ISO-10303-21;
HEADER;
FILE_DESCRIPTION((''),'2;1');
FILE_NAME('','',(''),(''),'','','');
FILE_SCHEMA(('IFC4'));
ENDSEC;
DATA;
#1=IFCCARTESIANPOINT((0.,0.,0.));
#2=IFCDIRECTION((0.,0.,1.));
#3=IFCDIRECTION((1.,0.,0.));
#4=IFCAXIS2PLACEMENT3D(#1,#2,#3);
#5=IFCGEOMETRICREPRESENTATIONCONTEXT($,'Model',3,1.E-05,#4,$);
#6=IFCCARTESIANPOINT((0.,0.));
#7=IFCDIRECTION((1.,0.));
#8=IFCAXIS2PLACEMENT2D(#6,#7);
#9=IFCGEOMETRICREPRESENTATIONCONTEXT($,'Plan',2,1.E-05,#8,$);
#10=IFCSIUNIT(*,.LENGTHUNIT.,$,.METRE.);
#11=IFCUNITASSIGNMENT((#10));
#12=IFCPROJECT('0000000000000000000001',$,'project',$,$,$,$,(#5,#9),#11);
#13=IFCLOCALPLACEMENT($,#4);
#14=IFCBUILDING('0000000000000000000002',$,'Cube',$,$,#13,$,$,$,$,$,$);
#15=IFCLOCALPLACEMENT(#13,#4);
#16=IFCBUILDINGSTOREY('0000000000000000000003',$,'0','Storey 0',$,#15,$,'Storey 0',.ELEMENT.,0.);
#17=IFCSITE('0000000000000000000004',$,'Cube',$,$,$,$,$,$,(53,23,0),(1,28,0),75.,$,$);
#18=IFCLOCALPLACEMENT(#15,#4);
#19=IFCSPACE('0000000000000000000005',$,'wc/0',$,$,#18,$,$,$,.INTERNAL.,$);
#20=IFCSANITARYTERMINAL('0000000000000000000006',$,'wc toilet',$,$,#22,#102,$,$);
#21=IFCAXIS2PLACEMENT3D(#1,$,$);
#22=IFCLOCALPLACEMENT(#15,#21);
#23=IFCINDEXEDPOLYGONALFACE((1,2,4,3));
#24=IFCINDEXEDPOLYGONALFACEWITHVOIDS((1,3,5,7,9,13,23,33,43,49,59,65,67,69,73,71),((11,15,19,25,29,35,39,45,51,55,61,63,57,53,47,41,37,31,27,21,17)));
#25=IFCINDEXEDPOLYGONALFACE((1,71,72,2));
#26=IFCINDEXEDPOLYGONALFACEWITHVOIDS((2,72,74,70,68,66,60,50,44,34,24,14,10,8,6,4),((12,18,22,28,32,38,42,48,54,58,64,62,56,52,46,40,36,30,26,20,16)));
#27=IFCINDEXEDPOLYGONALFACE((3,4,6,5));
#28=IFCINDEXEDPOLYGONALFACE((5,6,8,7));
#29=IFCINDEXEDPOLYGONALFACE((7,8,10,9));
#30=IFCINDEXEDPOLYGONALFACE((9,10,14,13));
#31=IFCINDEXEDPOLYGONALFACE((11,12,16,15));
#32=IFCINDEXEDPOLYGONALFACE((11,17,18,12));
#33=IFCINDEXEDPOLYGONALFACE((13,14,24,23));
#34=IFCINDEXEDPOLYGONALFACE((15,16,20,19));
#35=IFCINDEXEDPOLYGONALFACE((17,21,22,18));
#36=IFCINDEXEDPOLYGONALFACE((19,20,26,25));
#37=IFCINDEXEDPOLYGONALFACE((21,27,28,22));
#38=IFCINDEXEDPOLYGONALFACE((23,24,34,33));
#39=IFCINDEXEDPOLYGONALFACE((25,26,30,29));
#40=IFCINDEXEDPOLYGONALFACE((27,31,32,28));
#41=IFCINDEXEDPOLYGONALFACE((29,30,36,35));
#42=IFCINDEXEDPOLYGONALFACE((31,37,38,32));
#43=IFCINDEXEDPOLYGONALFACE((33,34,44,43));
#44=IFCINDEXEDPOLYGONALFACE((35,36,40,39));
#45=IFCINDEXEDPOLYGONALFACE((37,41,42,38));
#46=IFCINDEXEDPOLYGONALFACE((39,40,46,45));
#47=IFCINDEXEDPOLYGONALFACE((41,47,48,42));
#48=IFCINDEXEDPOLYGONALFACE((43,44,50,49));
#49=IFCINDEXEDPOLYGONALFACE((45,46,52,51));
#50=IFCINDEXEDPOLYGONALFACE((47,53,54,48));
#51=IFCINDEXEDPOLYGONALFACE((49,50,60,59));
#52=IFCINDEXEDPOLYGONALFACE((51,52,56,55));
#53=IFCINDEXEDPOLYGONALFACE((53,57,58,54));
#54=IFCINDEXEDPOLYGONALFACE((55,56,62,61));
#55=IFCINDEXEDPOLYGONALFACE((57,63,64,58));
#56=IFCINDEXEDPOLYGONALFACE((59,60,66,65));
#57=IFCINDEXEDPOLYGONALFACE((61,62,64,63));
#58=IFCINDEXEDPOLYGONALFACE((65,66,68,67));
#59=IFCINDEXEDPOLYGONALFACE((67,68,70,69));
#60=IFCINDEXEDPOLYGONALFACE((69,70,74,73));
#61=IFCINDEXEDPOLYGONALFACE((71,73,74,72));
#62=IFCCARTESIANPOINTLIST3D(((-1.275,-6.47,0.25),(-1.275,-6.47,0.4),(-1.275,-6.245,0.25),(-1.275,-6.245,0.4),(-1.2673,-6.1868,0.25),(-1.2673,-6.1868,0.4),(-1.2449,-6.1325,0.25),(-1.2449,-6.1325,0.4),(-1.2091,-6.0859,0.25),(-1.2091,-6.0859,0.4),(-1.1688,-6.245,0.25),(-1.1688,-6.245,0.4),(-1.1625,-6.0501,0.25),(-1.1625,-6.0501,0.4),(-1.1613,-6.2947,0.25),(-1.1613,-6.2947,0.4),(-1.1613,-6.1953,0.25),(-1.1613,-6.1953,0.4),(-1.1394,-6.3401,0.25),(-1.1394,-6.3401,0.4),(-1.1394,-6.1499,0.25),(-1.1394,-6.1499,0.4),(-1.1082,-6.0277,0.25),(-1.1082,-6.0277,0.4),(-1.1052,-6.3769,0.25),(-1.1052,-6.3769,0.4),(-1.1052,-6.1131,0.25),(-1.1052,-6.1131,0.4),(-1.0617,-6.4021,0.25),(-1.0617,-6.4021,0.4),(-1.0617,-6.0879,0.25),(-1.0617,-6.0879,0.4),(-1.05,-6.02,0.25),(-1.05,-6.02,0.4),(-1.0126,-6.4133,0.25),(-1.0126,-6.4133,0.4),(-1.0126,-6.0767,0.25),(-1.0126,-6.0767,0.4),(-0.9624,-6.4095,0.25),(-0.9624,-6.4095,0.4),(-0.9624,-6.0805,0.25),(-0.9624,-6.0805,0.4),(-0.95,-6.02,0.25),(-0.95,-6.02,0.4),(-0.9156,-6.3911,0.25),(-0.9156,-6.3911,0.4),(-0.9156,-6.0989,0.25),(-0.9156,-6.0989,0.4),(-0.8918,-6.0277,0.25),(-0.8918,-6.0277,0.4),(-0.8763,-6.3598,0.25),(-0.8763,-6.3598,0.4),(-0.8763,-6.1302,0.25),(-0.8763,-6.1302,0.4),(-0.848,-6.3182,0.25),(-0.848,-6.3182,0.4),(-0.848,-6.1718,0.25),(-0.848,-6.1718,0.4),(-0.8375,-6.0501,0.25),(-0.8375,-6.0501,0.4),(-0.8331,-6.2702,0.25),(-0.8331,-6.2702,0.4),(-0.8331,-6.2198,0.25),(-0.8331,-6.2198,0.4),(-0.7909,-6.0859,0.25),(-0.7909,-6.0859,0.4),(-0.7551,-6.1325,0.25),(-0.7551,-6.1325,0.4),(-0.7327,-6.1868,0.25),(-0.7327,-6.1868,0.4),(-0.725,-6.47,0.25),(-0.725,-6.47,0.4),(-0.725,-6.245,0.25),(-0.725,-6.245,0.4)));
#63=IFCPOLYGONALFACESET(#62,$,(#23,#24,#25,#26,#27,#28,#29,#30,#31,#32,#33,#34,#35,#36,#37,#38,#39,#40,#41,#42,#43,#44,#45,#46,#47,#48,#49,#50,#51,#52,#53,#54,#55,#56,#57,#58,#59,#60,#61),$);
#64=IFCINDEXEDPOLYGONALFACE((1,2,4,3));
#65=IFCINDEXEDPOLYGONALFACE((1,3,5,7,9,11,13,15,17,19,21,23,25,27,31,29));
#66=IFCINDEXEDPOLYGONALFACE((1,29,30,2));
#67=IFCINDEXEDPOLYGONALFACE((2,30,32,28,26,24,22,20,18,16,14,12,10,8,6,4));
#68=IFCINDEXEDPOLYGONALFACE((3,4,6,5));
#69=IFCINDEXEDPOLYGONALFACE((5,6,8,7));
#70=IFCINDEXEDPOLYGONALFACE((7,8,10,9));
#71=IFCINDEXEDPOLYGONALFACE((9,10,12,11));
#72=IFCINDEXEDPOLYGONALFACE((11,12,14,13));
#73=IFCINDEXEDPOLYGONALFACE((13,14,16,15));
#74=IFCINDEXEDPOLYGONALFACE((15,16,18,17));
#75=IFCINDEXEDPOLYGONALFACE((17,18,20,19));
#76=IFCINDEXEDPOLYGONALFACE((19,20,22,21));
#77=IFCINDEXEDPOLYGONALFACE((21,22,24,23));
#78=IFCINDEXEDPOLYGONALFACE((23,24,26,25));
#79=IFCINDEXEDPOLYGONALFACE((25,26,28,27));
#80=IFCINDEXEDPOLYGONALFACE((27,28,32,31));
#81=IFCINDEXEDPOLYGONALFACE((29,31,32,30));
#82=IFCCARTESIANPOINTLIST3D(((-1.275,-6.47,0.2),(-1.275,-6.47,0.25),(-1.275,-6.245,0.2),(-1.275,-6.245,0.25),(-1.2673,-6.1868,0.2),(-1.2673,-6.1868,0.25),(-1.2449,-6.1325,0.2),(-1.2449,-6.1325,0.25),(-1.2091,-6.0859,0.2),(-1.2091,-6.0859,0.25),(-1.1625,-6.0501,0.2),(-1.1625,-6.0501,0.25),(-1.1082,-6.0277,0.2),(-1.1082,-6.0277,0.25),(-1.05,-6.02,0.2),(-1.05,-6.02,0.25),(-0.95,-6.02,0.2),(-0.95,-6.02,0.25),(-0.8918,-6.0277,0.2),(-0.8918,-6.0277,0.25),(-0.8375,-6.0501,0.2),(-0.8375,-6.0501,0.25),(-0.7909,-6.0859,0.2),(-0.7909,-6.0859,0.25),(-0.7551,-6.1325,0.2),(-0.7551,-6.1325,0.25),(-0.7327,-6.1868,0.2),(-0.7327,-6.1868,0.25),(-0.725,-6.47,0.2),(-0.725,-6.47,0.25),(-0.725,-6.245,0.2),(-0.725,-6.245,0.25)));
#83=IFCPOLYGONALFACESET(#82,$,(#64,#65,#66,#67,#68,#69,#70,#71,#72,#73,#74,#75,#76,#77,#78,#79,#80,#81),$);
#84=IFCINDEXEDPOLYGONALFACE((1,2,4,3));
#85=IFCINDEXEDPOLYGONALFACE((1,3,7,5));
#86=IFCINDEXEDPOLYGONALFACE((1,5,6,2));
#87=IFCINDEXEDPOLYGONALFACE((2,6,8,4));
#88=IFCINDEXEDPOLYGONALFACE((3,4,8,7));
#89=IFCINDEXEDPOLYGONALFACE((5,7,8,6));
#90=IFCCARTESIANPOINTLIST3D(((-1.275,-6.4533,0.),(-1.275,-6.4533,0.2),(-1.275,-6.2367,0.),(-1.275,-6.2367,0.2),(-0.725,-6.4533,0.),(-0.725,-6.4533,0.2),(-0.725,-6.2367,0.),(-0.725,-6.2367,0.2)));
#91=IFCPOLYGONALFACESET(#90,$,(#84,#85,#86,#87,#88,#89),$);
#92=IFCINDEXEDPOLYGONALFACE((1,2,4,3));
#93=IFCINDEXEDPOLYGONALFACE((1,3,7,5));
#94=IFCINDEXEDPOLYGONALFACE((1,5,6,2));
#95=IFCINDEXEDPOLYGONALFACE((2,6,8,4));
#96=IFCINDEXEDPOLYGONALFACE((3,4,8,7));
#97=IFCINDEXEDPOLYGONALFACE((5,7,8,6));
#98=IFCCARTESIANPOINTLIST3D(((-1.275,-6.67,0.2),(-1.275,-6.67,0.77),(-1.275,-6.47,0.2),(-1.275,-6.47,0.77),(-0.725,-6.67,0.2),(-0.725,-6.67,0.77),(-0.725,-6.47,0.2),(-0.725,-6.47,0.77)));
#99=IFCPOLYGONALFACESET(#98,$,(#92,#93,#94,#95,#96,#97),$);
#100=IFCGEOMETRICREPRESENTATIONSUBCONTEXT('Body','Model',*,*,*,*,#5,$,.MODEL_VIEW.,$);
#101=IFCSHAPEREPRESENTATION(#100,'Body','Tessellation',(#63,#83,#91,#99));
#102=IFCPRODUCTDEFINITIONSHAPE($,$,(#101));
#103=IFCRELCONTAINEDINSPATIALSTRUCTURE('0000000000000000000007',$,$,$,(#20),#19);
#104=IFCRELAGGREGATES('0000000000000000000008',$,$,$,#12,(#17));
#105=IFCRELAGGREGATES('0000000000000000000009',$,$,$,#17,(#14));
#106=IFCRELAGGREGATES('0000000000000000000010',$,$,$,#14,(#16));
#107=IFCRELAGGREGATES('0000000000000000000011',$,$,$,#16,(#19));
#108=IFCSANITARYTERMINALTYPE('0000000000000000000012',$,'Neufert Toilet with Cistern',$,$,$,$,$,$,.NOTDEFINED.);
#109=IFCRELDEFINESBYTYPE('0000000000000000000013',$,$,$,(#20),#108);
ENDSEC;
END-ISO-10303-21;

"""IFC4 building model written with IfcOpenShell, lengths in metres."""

from ifc_helpers import new_model, entity, si_unit, frame, frame_2d, origin_with_axes, origin_2d_with_axis, place, context, subcontext, project, spatial, line, arc, indexed_curve, circle_curve, outline, extrude, shape, source, transform, mapped, type_object, type_shapes, element, save


model = new_model("IFC4")

# Units and contexts
model_context = context("Model", 3, precision=1e-05, world=origin_with_axes())
plan_context = context("Plan", 2, precision=1e-05, world=origin_2d_with_axis())
body_context_1 = subcontext(model_context, "Body", "Model", "MODEL_VIEW")
body_context_2 = subcontext(plan_context, "Body", "Plan", "PLAN_VIEW")
ifc_project = project(units=[si_unit("LENGTHUNIT", "METRE")], contexts=[model_context, plan_context])

# Site, building, storey
site = spatial("IfcSite", under=ifc_project, Name="Cube", RefLatitude=(53, 23, 0), RefLongitude=(1, 28, 0), RefElevation=75.0)
building_placement = place(None, origin_with_axes())
building = spatial("IfcBuilding", under=site, at=building_placement, Name="Cube")
storey_placement = place(building_placement, origin_with_axes())
storey = spatial("IfcBuildingStorey", under=building, at=storey_placement, Name="0", Description="Storey 0", LongName="Storey 0", CompositionType="ELEMENT", Elevation=0.0)

# Shared definitions
space_1_placement = place(storey_placement, origin_with_axes())
space_1 = spatial("IfcSpace", under=storey, at=space_1_placement, Name="wc/0", PredefinedType="INTERNAL")

# Sanitary terminal
sanitary_terminal_type_1 = type_object("IfcSanitaryTerminalType", Name="Neufert Toilet with Cistern", PredefinedType="NOTDEFINED")
shared_shape_1 = source(origin_with_axes(), body_context_1, "Body", "SweptSolid", [
    extrude(outline(indexed_curve([(-0.275, -0.2), (0.275, -0.2), (0.275, -0.425), (0.2091, -0.5841), (0.05, -0.65), (-0.05, -0.65), (-0.2091, -0.5841), (-0.275, -0.425)], segments=[line(1, 2), line(2, 3), arc(3, 4, 5), line(5, 6), arc(6, 7, 8), line(8, 1)]), holes=[circle_curve(frame_2d((0.0, -0.425)), 0.1688)]), frame((0.0, 0.0, 0.25), z_axis=(0.0, 0.0, 1.0), x_axis=(1.0, 0.0, 0.0)), (0.0, 0.0, 1.0), 0.15),
    extrude(outline(indexed_curve([(-0.275, -0.2), (0.275, -0.2), (0.275, -0.425), (0.2091, -0.5841), (0.05, -0.65), (-0.05, -0.65), (-0.2091, -0.5841), (-0.275, -0.425)], segments=[line(1, 2), line(2, 3), arc(3, 4, 5), line(5, 6), arc(6, 7, 8), line(8, 1)])), frame((0.0, 0.0, 0.2), z_axis=(0.0, 0.0, 1.0), x_axis=(1.0, 0.0, 0.0)), (0.0, 0.0, 1.0), 0.05),
    extrude(outline(indexed_curve([(-0.275, -0.2167), (0.275, -0.2167), (0.275, -0.4333), (-0.275, -0.4333)], segments=[line(1, 2, 3, 4, 1)])), origin_with_axes(), (0.0, 0.0, 1.0), 0.2),
    extrude(outline(indexed_curve([(-0.275, 0.0), (0.275, 0.0), (0.275, -0.2), (-0.275, -0.2)], segments=[line(1, 2, 3, 4, 1)])), frame((0.0, 0.0, 0.2), z_axis=(0.0, 0.0, 1.0), x_axis=(1.0, 0.0, 0.0)), (0.0, 0.0, 1.0), 0.57),
])
shared_shape_2 = source(origin_with_axes(), body_context_2, "Body", "Curve2D", [
    entity("IfcIndexedPolyCurve", entity("IfcCartesianPointList2D", [[-0.275, 0.0], [0.275, 0.0], [0.275, -0.2], [-0.275, -0.2]]), [entity("IfcLineIndex", [1, 2, 3, 4, 1])]),
    entity("IfcIndexedPolyCurve", entity("IfcCartesianPointList2D", [[0.165, -0.2], [0.1925, -0.335]])),
    entity("IfcTrimmedCurve", entity("IfcEllipse", entity("IfcAxis2Placement2D", entity("IfcCartesianPoint", [0.0, -0.335]), entity("IfcDirection", [1.0, 0.0])), 0.1925, 0.315), [entity("IfcCartesianPoint", [-0.1925, -0.335])], [entity("IfcCartesianPoint", [0.1925, -0.335])], True, "CARTESIAN"),
    entity("IfcIndexedPolyCurve", entity("IfcCartesianPointList2D", [[-0.165, -0.2], [-0.1925, -0.335]])),
    entity("IfcEllipse", entity("IfcAxis2Placement2D", entity("IfcCartesianPoint", [0.0, -0.452]), entity("IfcDirection", [1.0, 0.0])), 0.1313, 0.1575),
    entity("IfcIndexedPolyCurve", entity("IfcCartesianPointList2D", [[-0.0344, -0.452], [-0.0344, -0.4295], [0.0344, -0.4295], [0.0344, -0.452]])),
    entity("IfcTrimmedCurve", entity("IfcEllipse", entity("IfcAxis2Placement2D", entity("IfcCartesianPoint", [0.0, -0.452]), entity("IfcDirection", [1.0, 0.0])), 0.0344, 0.0225), [entity("IfcCartesianPoint", [-0.0344, -0.452])], [entity("IfcCartesianPoint", [0.0344, -0.452])], True, "CARTESIAN"),
])
type_shapes(sanitary_terminal_type_1, [shared_shape_1, shared_shape_2])
sanitary_terminal_1_placement = place(space_1_placement, frame((-1.0, -6.67, 0.0), z_axis=(0.0, 0.0, 1.0), x_axis=(-1.0, 0.0, 0.0)))
element("IfcSanitaryTerminal", 1, at=sanitary_terminal_1_placement, inside=space_1, type_object=sanitary_terminal_type_1, Name="wc toilet", shapes=[
    shape(body_context_1, "Body", "MappedRepresentation", [mapped(shared_shape_1, transform((0.0, 0.0, 0.0), x_axis=(1.0, 0.0, 0.0), y_axis=(0.0, 1.0, 0.0), z_axis=(0.0, 0.0, 1.0), scale=1.0))]),
    shape(body_context_2, "Body", "MappedRepresentation", [mapped(shared_shape_2, transform((0.0, 0.0, 0.0), x_axis=(1.0, 0.0, 0.0), y_axis=(0.0, 1.0, 0.0), z_axis=(0.0, 0.0, 1.0), scale=1.0))]),
])

save(model, "model.ifc")
